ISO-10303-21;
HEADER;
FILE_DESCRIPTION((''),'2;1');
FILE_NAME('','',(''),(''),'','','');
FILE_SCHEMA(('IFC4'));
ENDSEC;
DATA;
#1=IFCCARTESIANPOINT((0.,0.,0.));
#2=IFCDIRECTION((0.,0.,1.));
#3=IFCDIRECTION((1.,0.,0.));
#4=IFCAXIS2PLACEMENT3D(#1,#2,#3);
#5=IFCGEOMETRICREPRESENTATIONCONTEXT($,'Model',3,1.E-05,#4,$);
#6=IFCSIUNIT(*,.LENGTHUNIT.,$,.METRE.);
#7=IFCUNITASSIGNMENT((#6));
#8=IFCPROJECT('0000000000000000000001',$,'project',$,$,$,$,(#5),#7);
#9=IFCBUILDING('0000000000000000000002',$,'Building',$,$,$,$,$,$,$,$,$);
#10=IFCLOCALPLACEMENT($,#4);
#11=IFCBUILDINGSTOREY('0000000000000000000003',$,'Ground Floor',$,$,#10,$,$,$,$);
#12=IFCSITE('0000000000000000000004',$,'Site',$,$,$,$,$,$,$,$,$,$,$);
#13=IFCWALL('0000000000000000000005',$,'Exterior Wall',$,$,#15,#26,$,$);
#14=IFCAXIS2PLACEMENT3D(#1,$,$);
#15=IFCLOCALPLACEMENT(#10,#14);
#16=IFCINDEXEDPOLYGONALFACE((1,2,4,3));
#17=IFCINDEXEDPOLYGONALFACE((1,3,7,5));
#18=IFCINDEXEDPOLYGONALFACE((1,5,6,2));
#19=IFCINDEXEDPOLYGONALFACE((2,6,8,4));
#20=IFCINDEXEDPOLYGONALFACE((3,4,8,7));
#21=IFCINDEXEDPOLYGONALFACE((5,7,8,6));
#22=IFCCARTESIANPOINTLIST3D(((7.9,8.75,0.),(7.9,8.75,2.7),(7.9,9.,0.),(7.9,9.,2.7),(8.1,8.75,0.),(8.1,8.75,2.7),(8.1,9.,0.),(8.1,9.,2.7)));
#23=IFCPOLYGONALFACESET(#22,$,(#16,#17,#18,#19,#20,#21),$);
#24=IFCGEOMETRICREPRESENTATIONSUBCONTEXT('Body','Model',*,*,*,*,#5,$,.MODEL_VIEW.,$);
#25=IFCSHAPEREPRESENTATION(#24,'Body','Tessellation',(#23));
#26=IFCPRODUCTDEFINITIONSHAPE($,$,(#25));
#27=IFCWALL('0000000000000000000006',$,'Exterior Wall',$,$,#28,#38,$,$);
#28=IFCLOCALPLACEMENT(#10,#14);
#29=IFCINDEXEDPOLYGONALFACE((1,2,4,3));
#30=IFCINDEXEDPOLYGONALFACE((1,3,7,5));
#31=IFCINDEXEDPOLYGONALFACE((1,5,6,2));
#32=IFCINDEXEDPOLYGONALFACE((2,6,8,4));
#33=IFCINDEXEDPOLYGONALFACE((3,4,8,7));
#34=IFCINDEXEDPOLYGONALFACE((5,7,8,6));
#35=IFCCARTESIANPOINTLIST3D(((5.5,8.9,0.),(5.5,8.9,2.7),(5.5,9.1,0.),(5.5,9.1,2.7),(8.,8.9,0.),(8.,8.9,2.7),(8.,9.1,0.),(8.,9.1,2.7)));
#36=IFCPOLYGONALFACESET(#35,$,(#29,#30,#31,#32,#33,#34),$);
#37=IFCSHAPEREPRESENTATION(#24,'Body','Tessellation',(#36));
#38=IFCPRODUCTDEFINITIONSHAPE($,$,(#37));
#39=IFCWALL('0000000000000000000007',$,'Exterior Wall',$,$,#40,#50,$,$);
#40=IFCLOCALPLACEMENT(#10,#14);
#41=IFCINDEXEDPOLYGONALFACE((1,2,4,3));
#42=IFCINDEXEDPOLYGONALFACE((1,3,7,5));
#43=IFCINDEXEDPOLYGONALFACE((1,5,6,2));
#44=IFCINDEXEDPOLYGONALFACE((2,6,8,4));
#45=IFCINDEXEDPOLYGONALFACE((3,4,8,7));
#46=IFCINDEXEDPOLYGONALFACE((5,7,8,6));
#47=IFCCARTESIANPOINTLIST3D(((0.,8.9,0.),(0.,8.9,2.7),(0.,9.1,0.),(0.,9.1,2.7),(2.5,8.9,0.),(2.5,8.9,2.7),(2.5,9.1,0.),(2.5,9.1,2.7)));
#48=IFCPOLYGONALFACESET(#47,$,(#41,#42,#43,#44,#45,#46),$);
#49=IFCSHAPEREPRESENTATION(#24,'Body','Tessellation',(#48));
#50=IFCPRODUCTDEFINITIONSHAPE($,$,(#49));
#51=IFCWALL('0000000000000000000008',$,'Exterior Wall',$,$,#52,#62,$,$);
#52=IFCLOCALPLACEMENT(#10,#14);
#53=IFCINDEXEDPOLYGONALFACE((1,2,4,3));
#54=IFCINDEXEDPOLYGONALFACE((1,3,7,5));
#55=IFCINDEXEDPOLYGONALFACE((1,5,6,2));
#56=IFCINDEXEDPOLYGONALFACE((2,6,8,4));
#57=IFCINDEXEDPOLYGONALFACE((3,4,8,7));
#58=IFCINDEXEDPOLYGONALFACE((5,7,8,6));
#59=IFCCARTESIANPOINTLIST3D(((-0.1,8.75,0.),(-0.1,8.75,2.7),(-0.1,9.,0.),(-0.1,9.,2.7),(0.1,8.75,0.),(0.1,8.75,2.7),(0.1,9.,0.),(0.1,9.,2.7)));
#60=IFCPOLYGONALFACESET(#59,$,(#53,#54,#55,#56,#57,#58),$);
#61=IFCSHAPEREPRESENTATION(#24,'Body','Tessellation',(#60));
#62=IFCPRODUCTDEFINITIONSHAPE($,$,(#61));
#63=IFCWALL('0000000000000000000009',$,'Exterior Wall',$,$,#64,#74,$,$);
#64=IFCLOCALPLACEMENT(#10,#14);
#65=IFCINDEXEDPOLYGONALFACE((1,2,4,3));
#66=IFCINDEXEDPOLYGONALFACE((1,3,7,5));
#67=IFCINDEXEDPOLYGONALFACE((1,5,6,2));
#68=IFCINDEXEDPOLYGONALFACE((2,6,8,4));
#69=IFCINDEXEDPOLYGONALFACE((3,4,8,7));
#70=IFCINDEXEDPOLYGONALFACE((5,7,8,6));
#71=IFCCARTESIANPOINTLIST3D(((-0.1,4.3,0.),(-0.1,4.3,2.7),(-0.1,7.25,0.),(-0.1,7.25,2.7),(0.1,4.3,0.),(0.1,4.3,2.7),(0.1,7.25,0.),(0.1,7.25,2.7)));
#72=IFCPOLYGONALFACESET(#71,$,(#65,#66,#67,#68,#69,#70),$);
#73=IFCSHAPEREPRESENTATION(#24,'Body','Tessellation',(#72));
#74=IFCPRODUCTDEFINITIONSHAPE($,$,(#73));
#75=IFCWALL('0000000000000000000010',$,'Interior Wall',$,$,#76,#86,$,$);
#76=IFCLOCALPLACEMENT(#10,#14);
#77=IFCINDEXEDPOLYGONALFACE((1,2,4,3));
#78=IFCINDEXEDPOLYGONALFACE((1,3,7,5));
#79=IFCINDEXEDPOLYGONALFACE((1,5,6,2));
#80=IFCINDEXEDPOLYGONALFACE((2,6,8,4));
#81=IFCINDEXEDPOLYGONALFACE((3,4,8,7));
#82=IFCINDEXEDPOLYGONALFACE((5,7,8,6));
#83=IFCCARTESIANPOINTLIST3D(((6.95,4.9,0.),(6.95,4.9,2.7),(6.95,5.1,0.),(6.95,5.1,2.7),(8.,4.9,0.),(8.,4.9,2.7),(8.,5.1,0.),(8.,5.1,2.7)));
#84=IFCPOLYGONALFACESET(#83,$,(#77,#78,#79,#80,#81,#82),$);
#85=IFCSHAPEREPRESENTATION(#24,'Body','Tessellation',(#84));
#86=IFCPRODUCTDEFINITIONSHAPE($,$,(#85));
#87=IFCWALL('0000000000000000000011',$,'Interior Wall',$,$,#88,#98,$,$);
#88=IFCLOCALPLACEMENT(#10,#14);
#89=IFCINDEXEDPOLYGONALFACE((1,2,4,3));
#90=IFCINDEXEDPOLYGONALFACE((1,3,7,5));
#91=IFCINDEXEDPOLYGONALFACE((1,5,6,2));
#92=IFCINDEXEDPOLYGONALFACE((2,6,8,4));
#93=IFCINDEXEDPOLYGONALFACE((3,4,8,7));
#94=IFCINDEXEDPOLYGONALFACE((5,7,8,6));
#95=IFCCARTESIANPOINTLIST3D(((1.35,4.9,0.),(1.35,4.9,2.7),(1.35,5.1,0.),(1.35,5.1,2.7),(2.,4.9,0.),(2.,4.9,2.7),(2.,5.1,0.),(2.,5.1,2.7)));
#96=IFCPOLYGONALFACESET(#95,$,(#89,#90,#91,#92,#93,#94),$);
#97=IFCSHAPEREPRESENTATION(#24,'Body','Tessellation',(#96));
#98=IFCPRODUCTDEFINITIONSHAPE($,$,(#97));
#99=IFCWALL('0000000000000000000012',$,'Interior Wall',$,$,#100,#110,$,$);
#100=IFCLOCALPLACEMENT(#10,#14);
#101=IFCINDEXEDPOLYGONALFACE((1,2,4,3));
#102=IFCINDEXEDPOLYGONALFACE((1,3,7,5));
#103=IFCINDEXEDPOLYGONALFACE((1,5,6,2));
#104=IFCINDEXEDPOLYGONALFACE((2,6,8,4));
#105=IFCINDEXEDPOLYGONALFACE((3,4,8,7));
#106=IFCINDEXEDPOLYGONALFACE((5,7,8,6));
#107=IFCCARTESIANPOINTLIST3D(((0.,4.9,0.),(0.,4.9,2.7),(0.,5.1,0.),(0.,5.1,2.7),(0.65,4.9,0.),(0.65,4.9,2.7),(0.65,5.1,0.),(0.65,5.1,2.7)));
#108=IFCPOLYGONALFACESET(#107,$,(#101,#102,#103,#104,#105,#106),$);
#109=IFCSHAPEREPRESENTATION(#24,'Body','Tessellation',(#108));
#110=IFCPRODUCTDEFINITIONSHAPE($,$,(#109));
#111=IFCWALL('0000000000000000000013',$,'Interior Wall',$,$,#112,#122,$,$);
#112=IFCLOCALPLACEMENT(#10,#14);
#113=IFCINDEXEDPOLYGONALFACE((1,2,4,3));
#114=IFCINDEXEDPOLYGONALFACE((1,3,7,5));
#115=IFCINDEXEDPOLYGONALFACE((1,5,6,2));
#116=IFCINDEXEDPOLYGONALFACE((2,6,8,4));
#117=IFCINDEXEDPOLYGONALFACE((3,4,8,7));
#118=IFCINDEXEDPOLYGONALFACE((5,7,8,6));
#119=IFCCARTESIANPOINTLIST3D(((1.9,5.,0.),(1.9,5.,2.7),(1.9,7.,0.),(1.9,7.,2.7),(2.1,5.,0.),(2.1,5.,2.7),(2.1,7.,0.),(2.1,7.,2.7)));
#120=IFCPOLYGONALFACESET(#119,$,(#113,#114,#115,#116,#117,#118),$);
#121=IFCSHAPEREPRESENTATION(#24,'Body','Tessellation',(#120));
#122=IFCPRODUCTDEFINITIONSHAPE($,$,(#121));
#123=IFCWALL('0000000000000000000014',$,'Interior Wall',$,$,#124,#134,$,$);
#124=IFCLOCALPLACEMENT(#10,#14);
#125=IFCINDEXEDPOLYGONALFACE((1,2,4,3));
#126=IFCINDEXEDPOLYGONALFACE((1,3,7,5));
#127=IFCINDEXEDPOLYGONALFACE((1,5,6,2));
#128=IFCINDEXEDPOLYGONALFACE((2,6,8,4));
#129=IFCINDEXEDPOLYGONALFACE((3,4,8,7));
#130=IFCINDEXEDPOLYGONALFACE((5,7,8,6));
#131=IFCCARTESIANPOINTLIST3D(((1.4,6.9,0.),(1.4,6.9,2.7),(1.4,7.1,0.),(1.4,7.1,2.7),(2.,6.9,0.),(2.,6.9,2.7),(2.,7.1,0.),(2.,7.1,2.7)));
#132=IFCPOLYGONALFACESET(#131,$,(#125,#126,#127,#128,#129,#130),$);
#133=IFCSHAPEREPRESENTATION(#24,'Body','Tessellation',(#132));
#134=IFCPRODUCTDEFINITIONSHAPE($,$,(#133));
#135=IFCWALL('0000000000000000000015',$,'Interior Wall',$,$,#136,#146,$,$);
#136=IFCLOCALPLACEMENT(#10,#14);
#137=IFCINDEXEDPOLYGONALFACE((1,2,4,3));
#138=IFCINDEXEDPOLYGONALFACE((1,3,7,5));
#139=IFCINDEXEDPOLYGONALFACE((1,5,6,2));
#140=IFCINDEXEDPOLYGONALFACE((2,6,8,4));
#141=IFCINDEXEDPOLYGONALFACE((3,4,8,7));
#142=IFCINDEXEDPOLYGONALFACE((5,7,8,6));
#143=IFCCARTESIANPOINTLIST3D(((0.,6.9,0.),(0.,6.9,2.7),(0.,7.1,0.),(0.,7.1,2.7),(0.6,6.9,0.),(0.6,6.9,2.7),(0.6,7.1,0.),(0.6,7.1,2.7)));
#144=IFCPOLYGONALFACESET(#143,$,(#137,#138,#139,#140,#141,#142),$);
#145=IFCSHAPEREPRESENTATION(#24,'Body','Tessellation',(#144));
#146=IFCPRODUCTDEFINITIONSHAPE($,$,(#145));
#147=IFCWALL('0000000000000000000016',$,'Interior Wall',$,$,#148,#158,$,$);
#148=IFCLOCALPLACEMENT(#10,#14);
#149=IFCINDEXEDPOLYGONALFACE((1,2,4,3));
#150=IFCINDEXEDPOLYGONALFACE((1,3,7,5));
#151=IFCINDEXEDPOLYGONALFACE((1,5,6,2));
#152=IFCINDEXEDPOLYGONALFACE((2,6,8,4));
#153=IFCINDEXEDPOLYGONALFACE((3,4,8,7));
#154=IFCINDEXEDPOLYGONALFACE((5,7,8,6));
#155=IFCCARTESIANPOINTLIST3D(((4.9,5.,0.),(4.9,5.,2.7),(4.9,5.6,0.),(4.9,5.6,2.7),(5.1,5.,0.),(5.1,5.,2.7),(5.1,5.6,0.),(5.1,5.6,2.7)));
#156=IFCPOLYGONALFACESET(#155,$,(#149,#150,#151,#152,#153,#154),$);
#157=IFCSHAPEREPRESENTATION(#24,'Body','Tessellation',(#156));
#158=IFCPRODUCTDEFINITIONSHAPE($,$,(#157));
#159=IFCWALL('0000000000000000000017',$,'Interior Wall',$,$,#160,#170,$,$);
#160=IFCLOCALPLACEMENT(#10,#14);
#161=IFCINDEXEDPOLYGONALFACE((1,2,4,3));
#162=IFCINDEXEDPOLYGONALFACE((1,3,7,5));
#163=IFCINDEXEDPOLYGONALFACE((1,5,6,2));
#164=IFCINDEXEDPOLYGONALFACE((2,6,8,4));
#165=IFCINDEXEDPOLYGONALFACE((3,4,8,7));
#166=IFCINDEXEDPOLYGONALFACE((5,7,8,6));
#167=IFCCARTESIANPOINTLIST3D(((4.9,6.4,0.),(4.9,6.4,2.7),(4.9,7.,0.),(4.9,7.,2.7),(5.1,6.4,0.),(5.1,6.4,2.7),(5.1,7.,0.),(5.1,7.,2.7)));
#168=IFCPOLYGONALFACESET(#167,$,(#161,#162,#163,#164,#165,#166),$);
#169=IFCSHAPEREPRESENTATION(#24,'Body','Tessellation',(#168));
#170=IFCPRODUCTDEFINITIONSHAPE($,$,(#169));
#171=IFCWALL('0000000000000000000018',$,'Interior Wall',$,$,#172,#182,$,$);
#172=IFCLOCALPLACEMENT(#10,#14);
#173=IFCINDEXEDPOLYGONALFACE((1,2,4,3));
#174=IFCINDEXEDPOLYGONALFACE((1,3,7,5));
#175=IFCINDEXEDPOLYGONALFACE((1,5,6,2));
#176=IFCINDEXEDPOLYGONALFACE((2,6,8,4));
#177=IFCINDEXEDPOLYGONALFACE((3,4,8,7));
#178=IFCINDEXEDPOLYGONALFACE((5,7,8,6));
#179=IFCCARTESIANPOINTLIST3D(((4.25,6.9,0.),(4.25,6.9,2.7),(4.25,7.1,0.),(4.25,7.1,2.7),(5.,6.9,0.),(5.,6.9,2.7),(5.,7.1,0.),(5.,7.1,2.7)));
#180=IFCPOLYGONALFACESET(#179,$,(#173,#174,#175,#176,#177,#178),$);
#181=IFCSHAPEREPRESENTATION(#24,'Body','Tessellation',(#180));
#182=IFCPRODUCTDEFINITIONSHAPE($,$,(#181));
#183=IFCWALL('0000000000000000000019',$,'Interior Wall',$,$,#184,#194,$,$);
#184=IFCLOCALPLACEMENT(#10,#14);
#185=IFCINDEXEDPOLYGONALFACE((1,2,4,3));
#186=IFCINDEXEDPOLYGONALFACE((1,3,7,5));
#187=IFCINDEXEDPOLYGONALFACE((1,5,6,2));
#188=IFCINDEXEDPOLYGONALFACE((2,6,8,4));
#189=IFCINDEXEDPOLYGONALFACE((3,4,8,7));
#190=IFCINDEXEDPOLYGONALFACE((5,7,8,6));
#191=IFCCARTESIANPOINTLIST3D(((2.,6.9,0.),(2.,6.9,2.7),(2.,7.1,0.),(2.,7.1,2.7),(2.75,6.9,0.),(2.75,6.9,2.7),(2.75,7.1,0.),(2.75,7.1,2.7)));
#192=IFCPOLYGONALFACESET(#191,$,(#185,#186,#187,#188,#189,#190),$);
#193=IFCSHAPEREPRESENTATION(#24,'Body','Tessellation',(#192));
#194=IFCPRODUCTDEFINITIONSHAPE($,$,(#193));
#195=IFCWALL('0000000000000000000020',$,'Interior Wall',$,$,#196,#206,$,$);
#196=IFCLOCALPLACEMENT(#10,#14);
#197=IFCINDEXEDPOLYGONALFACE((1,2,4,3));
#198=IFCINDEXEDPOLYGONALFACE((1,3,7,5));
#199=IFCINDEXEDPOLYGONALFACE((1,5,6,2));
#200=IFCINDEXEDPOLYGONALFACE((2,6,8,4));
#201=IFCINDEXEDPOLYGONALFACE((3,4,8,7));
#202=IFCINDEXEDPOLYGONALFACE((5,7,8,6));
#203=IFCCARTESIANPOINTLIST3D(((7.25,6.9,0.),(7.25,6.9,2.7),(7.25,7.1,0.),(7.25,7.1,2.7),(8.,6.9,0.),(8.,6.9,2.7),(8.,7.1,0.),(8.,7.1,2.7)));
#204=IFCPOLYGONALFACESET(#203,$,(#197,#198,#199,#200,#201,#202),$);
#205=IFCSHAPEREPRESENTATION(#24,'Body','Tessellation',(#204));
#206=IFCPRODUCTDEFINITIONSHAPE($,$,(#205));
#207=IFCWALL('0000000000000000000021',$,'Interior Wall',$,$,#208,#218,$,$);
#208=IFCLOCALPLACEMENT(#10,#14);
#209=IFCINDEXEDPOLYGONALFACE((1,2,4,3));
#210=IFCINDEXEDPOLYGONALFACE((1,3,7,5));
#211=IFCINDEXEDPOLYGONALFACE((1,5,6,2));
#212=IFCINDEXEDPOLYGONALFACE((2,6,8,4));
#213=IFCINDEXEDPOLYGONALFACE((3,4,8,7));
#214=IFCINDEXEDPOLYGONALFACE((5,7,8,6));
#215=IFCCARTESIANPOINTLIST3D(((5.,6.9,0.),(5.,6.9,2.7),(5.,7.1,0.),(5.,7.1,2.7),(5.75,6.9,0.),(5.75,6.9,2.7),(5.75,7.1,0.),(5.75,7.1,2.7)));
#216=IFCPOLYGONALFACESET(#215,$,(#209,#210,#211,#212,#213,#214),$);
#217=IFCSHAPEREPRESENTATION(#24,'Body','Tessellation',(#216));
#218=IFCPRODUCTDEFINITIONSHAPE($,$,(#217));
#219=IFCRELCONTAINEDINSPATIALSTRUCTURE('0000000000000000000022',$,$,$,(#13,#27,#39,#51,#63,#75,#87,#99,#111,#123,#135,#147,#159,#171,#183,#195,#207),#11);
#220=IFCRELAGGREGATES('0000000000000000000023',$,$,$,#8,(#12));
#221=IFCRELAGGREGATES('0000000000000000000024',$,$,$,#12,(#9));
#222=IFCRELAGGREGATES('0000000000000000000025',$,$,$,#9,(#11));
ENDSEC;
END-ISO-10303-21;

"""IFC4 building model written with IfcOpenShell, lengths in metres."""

from ifc_helpers import new_model, si_unit, frame, origin_with_axes, place, context, subcontext, project, spatial, indexed_curve, outline, extrude, element, save


model = new_model("IFC4")

# Units and contexts
model_context = context("Model", 3, precision=1e-05, world=origin_with_axes())
body_context = subcontext(model_context, "Body", "Model", "MODEL_VIEW")
ifc_project = project(units=[si_unit("LENGTHUNIT", "METRE")], contexts=[model_context])

# Site, building, storey
site = spatial("IfcSite", under=ifc_project, Name="Site")
building = spatial("IfcBuilding", under=site, Name="Building")
storey_placement = place(None, origin_with_axes())
storey = spatial("IfcBuildingStorey", under=building, at=storey_placement, Name="Ground Floor")

# Walls
wall_1_placement = place(storey_placement, frame((8.0, 8.75, 0.0), z_axis=(0.0, 0.0, 1.0), x_axis=(0.0, 1.0, 0.0)))
element("IfcWall", 1, at=wall_1_placement, inside=storey, Name="Exterior Wall", context=body_context, shape_type="SweptSolid", body=[
    extrude(outline(indexed_curve([(0.0, 0.0), (0.0, 0.2), (0.25, 0.2), (0.25, 0.0), (0.0, 0.0)], self_intersect=False)), frame((0.0, -0.1, 0.0), z_axis=(0.0, 0.0, 1.0), x_axis=(1.0, 0.0, 0.0)), (0.0, 0.0, 1.0), 2.7),
])
for number, where, z_axis, x_axis, name in (
    (2, (8.0, 9.0, 0.0), (0.0, 0.0, 1.0), (-1.0, 0.0, 0.0), "Exterior Wall"),
    (3, (2.5, 9.0, 0.0), (0.0, 0.0, 1.0), (-1.0, 0.0, 0.0), "Exterior Wall"),
):
    element("IfcWall", number, at=place(storey_placement, frame(where, z_axis=z_axis, x_axis=x_axis)), inside=storey, Name=name, context=body_context, shape_type="SweptSolid", body=[
        extrude(outline(indexed_curve([(0.0, 0.0), (0.0, 0.2), (2.5, 0.2), (2.5, 0.0), (0.0, 0.0)], self_intersect=False)), frame((0.0, -0.1, 0.0), z_axis=(0.0, 0.0, 1.0), x_axis=(1.0, 0.0, 0.0)), (0.0, 0.0, 1.0), 2.7),
    ])
wall_2_placement = place(storey_placement, frame((0.0, 9.0, 0.0), z_axis=(0.0, 0.0, 1.0), x_axis=(0.0, -1.0, 0.0)))
element("IfcWall", 4, at=wall_2_placement, inside=storey, Name="Exterior Wall", context=body_context, shape_type="SweptSolid", body=[
    extrude(outline(indexed_curve([(0.0, 0.0), (0.0, 0.2), (0.25, 0.2), (0.25, 0.0), (0.0, 0.0)], self_intersect=False)), frame((0.0, -0.1, 0.0), z_axis=(0.0, 0.0, 1.0), x_axis=(1.0, 0.0, 0.0)), (0.0, 0.0, 1.0), 2.7),
])
wall_3_placement = place(storey_placement, frame((0.0, 7.25, 0.0), z_axis=(0.0, 0.0, 1.0), x_axis=(0.0, -1.0, 0.0)))
element("IfcWall", 5, at=wall_3_placement, inside=storey, Name="Exterior Wall", context=body_context, shape_type="SweptSolid", body=[
    extrude(outline(indexed_curve([(0.0, 0.0), (0.0, 0.2), (2.95, 0.2), (2.95, 0.0), (0.0, 0.0)], self_intersect=False)), frame((0.0, -0.1, 0.0), z_axis=(0.0, 0.0, 1.0), x_axis=(1.0, 0.0, 0.0)), (0.0, 0.0, 1.0), 2.7),
])
wall_4_placement = place(storey_placement, frame((8.0, 5.0, 0.0), z_axis=(0.0, 0.0, 1.0), x_axis=(-1.0, 0.0, 0.0)))
element("IfcWall", 6, at=wall_4_placement, inside=storey, Name="Interior Wall", context=body_context, shape_type="SweptSolid", body=[
    extrude(outline(indexed_curve([(0.0, 0.0), (0.0, 0.2), (1.05, 0.2), (1.05, 0.0), (0.0, 0.0)], self_intersect=False)), frame((0.0, -0.1, 0.0), z_axis=(0.0, 0.0, 1.0), x_axis=(1.0, 0.0, 0.0)), (0.0, 0.0, 1.0), 2.7),
])
for number, where, z_axis, x_axis, name in (
    (7, (2.0, 5.0, 0.0), (0.0, 0.0, 1.0), (-1.0, 0.0, 0.0), "Interior Wall"),
    (8, (0.65, 5.0, 0.0), (0.0, 0.0, 1.0), (-1.0, 0.0, 0.0), "Interior Wall"),
):
    element("IfcWall", number, at=place(storey_placement, frame(where, z_axis=z_axis, x_axis=x_axis)), inside=storey, Name=name, context=body_context, shape_type="SweptSolid", body=[
        extrude(outline(indexed_curve([(0.0, 0.0), (0.0, 0.2), (0.65, 0.2), (0.65, 0.0), (0.0, 0.0)], self_intersect=False)), frame((0.0, -0.1, 0.0), z_axis=(0.0, 0.0, 1.0), x_axis=(1.0, 0.0, 0.0)), (0.0, 0.0, 1.0), 2.7),
    ])
wall_5_placement = place(storey_placement, frame((2.0, 5.0, 0.0), z_axis=(0.0, 0.0, 1.0), x_axis=(0.0, 1.0, 0.0)))
element("IfcWall", 9, at=wall_5_placement, inside=storey, Name="Interior Wall", context=body_context, shape_type="SweptSolid", body=[
    extrude(outline(indexed_curve([(0.0, 0.0), (0.0, 0.2), (2.0, 0.2), (2.0, 0.0), (0.0, 0.0)], self_intersect=False)), frame((0.0, -0.1, 0.0), z_axis=(0.0, 0.0, 1.0), x_axis=(1.0, 0.0, 0.0)), (0.0, 0.0, 1.0), 2.7),
])
for number, where, z_axis, x_axis, name in (
    (10, (2.0, 7.0, 0.0), (0.0, 0.0, 1.0), (-1.0, 0.0, 0.0), "Interior Wall"),
    (11, (0.6, 7.0, 0.0), (0.0, 0.0, 1.0), (-1.0, 0.0, 0.0), "Interior Wall"),
):
    element("IfcWall", number, at=place(storey_placement, frame(where, z_axis=z_axis, x_axis=x_axis)), inside=storey, Name=name, context=body_context, shape_type="SweptSolid", body=[
        extrude(outline(indexed_curve([(0.0, 0.0), (0.0, 0.2), (0.6, 0.2), (0.6, 0.0), (0.0, 0.0)], self_intersect=False)), frame((0.0, -0.1, 0.0), z_axis=(0.0, 0.0, 1.0), x_axis=(1.0, 0.0, 0.0)), (0.0, 0.0, 1.0), 2.7),
    ])
for number, where, z_axis, x_axis, name in (
    (12, (5.0, 5.0, 0.0), (0.0, 0.0, 1.0), (0.0, 1.0, 0.0), "Interior Wall"),
    (13, (5.0, 6.4, 0.0), (0.0, 0.0, 1.0), (0.0, 1.0, 0.0), "Interior Wall"),
):
    element("IfcWall", number, at=place(storey_placement, frame(where, z_axis=z_axis, x_axis=x_axis)), inside=storey, Name=name, context=body_context, shape_type="SweptSolid", body=[
        extrude(outline(indexed_curve([(0.0, 0.0), (0.0, 0.2), (0.6, 0.2), (0.6, 0.0), (0.0, 0.0)], self_intersect=False)), frame((0.0, -0.1, 0.0), z_axis=(0.0, 0.0, 1.0), x_axis=(1.0, 0.0, 0.0)), (0.0, 0.0, 1.0), 2.7),
    ])
for number, where, z_axis, x_axis, name in (
    (14, (5.0, 7.0, 0.0), (0.0, 0.0, 1.0), (-1.0, 0.0, 0.0), "Interior Wall"),
    (15, (2.75, 7.0, 0.0), (0.0, 0.0, 1.0), (-1.0, 0.0, 0.0), "Interior Wall"),
    (16, (8.0, 7.0, 0.0), (0.0, 0.0, 1.0), (-1.0, 0.0, 0.0), "Interior Wall"),
    (17, (5.75, 7.0, 0.0), (0.0, 0.0, 1.0), (-1.0, 0.0, 0.0), "Interior Wall"),
):
    element("IfcWall", number, at=place(storey_placement, frame(where, z_axis=z_axis, x_axis=x_axis)), inside=storey, Name=name, context=body_context, shape_type="SweptSolid", body=[
        extrude(outline(indexed_curve([(0.0, 0.0), (0.0, 0.2), (0.75, 0.2), (0.75, 0.0), (0.0, 0.0)], self_intersect=False)), frame((0.0, -0.1, 0.0), z_axis=(0.0, 0.0, 1.0), x_axis=(1.0, 0.0, 0.0)), (0.0, 0.0, 1.0), 2.7),
    ])

save(model, "model.ifc")
